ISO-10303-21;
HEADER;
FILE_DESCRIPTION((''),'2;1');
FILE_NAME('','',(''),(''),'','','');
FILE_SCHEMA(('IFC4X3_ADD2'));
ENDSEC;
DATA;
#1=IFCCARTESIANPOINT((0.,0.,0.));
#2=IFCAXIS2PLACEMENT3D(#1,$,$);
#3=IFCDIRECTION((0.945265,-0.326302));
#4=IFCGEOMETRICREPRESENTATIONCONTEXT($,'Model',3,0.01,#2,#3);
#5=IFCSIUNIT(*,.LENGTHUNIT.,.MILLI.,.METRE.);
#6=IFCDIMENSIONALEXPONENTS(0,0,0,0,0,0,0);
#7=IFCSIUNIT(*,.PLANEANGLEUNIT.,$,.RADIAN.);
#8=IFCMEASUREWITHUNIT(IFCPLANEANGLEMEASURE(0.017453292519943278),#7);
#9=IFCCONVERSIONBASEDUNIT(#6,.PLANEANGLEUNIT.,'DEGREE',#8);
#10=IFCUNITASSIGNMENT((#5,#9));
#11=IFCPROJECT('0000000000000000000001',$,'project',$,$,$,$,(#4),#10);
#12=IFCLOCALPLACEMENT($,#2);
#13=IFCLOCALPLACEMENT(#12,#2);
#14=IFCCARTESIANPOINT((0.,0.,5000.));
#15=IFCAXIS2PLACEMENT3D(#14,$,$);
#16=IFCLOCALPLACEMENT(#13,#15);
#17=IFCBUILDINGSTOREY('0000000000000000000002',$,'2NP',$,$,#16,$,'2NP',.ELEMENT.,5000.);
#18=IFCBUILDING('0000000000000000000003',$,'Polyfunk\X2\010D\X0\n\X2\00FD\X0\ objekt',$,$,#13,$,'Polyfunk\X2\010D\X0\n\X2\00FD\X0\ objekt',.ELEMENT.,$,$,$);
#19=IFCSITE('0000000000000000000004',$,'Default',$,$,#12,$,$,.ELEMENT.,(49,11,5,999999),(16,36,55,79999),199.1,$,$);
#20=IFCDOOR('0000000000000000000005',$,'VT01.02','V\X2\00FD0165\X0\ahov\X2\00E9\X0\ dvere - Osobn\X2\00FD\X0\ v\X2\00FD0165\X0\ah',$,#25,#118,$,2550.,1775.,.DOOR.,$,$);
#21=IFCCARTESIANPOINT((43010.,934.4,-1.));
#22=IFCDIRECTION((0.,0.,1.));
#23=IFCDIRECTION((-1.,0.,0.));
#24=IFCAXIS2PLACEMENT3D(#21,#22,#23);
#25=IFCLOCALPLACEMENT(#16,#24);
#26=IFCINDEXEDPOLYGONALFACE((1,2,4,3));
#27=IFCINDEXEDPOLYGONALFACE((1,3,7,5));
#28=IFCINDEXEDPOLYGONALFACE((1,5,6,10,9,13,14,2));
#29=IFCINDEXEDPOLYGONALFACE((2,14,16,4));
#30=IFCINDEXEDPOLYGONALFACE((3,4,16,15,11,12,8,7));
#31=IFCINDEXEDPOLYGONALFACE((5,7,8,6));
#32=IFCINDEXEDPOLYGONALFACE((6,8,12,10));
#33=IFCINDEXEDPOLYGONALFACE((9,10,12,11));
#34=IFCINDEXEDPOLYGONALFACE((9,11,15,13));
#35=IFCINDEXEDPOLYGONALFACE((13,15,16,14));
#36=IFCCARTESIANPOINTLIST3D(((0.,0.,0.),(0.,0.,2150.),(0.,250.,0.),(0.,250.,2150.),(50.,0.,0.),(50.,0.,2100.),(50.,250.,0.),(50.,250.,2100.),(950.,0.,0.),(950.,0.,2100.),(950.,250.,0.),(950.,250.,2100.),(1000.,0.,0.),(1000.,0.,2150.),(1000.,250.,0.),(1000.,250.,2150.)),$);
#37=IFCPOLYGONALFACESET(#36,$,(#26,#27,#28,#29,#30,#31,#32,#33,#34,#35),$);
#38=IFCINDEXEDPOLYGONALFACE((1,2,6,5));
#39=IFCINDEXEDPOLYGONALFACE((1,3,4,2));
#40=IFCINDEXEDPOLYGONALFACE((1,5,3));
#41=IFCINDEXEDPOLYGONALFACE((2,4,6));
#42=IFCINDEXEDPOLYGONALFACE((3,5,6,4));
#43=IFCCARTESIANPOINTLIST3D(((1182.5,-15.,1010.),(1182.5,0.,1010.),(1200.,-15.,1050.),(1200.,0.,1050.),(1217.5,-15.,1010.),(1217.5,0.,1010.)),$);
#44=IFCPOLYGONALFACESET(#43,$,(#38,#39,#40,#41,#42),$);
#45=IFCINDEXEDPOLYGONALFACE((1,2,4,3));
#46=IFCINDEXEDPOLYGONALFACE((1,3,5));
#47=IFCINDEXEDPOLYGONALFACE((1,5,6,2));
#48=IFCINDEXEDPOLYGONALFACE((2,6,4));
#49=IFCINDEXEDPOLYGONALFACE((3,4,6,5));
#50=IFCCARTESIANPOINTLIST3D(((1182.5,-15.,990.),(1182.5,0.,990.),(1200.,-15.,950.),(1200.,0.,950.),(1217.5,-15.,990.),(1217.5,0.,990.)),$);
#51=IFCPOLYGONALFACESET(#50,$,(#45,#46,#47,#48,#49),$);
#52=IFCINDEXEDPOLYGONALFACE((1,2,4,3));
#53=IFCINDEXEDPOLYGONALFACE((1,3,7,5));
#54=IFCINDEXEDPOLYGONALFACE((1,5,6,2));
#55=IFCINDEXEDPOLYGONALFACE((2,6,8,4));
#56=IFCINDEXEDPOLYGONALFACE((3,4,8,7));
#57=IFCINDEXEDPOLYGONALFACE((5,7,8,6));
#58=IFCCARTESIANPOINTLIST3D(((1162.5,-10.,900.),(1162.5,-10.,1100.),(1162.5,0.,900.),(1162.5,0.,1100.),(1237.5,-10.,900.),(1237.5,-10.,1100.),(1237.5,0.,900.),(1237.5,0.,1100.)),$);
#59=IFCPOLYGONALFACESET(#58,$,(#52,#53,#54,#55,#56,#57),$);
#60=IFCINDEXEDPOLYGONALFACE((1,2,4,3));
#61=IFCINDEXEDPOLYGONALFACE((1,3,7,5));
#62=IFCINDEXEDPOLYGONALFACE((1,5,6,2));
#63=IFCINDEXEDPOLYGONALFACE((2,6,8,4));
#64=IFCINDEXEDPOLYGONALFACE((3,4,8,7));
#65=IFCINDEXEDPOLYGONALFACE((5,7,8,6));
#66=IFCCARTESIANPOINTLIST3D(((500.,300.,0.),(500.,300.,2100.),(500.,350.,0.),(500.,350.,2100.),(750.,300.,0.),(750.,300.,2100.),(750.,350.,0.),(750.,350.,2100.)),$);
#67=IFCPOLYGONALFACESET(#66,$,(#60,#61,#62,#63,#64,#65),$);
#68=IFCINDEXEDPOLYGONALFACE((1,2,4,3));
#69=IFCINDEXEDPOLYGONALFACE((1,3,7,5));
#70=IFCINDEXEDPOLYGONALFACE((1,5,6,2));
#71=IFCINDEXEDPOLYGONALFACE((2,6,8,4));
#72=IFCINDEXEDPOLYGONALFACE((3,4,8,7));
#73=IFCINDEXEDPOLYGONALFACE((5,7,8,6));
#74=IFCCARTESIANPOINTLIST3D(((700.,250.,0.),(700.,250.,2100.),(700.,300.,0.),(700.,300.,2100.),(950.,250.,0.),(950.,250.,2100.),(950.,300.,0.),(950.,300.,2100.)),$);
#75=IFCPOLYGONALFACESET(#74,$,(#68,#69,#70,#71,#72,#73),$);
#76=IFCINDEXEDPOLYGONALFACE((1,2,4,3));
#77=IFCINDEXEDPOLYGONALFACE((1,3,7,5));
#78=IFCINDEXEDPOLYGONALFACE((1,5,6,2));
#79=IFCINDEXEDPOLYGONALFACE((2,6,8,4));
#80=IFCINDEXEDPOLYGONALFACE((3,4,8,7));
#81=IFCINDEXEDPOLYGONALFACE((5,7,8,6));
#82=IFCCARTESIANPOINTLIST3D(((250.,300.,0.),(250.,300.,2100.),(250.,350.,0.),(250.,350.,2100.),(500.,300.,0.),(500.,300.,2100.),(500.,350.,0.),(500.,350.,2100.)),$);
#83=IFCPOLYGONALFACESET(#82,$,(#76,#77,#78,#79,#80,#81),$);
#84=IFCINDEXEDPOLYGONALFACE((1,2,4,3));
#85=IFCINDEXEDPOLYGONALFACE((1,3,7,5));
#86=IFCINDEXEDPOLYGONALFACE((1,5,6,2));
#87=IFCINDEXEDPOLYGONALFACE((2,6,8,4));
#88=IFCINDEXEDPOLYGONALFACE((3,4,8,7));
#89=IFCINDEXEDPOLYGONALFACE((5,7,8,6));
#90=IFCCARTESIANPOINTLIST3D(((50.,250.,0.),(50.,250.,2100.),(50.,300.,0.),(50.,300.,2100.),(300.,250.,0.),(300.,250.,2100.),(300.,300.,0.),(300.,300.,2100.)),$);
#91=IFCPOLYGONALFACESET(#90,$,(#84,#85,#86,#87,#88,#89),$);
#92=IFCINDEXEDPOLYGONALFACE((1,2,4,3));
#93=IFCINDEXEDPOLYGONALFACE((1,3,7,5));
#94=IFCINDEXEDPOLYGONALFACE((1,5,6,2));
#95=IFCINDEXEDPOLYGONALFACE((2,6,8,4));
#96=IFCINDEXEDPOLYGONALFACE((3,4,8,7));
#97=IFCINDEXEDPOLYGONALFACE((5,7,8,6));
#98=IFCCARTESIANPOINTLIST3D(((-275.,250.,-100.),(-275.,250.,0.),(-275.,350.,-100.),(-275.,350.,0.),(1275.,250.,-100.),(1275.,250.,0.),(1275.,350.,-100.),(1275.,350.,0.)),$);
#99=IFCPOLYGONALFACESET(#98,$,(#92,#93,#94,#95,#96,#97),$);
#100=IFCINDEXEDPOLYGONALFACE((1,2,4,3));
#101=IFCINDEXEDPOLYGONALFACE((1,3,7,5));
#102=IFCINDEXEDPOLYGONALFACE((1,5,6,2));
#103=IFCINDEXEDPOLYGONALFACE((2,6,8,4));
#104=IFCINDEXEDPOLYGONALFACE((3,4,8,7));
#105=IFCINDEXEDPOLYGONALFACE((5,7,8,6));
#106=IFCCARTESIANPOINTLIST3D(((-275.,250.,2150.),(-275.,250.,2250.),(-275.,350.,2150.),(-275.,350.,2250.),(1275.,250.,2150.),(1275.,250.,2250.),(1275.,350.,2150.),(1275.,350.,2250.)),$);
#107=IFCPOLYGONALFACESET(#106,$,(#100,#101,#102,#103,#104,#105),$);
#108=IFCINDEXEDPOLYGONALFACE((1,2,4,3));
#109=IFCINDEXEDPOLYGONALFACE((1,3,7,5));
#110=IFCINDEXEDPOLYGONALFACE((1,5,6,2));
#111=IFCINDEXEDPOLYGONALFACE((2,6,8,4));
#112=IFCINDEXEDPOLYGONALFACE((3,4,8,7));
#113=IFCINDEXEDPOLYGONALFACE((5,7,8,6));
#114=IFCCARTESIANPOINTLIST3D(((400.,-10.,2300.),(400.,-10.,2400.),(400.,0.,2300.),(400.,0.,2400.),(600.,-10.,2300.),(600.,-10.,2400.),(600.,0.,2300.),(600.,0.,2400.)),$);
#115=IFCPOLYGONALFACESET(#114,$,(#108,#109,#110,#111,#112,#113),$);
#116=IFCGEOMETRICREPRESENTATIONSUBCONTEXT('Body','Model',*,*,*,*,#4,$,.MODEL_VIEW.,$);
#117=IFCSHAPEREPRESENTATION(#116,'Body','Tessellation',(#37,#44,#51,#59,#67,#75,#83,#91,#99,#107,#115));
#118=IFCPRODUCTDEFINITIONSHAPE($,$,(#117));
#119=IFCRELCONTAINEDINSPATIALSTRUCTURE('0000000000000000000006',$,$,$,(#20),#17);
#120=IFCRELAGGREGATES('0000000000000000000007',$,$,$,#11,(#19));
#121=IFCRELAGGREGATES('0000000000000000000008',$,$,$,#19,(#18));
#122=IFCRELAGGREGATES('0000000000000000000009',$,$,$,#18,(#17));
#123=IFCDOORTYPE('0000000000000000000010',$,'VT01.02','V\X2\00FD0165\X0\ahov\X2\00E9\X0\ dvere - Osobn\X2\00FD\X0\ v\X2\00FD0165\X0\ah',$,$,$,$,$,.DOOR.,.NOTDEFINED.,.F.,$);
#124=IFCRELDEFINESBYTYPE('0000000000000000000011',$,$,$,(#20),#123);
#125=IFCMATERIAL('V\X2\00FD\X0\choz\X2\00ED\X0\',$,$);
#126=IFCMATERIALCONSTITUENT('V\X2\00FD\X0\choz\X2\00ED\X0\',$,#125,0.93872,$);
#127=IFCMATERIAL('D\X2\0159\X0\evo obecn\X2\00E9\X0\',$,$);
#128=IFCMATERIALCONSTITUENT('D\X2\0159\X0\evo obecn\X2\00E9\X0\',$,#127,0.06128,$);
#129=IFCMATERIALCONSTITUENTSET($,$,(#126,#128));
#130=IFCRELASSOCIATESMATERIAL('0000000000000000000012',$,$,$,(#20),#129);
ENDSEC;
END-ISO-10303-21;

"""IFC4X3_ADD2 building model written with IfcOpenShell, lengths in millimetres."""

from ifc_helpers import new_model, entity, si_unit, converted_unit, direction, frame, frame_2d, origin, origin_2d_with_axis, place, context, subcontext, project, spatial, polyline, rectangle, outline, extrude, source, transform, mapped, material, constituent, constituent_set, type_object, type_shapes, element, save


model = new_model("IFC4X3_ADD2")

# Units and contexts
model_context = context("Model", 3, precision=0.01, world=origin(), true_north=direction((0.945265, -0.326302)))
body_context = subcontext(model_context, "Body", "Model", "MODEL_VIEW")
ifc_project = project(units=[si_unit("LENGTHUNIT", "METRE", prefix="MILLI"), converted_unit("PLANEANGLEUNIT", "DEGREE", entity("IfcPlaneAngleMeasure", 0.017453292519943278), si_unit("PLANEANGLEUNIT", "RADIAN"), dimensions=[0, 0, 0, 0, 0, 0, 0])], contexts=[model_context])

# Site, building, storey
site_placement = place(None, origin())
site = spatial("IfcSite", under=ifc_project, at=site_placement, Name="Default", CompositionType="ELEMENT", RefLatitude=(49, 11, 5, 999999), RefLongitude=(16, 36, 55, 79999), RefElevation=199.1)
building_placement = place(site_placement, origin())
building = spatial("IfcBuilding", under=site, at=building_placement, Name="Polyfunkčný objekt", LongName="Polyfunkčný objekt", CompositionType="ELEMENT")
storey_placement = place(building_placement, frame((0.0, 0.0, 5000.0)))
storey = spatial("IfcBuildingStorey", under=building, at=storey_placement, Name="2NP", LongName="2NP", CompositionType="ELEMENT", Elevation=5000.0)

# Shared definitions
ifc_material_1 = material(Name="Dřevo obecné")

# Door
ifc_material_2 = material(Name="Výchozí")
ifc_constituent_1 = constituent(ifc_material_2, Name="Výchozí", fraction=0.93872)
ifc_constituent_2 = constituent(ifc_material_1, Name="Dřevo obecné", fraction=0.06128)
ifc_constituent_set_1 = constituent_set(constituents=[ifc_constituent_1, ifc_constituent_2])
door_type = type_object("IfcDoorType", Name="VT01.02", Description="Výťahové dvere - Osobný výťah", OperationType="NOTDEFINED", ParameterTakesPrecedence=False, PredefinedType="DOOR")
shared_shape_1 = source(origin(), body_context, "Body", "SweptSolid", [
    extrude(outline(polyline([(-1087.5, -500.0), (1062.5, -500.0), (1062.5, -450.0), (-1037.5, -450.0), (-1037.5, 450.0), (1062.5, 450.0), (1062.5, 500.0), (-1087.5, 500.0), (-1087.5, -500.0)])), frame((500.0, 0.0, 1062.5), z_axis=(0.0, 1.0, 0.0), x_axis=(0.0, 0.0, -1.0)), (0.0, 0.0, 1.0), 250.0),
    extrude(outline(polyline([(-24.4, -10.7), (19.2, -10.7), (5.2, 21.4), (-24.4, -10.7)])), frame((1200.0, -15.0, 1023.3), z_axis=(0.0, 1.0, 0.0), x_axis=(0.400819, 0.0, -0.916157)), (0.0, 0.0, 1.0), 15.0),
    extrude(outline(polyline([(-24.4, -10.7), (19.2, -10.7), (5.2, 21.4), (-24.4, -10.7)])), frame((1200.0, -15.0, 976.7), z_axis=(0.0, 1.0, 0.0), x_axis=(-0.400819, 0.0, 0.916157)), (0.0, 0.0, 1.0), 15.0),
    extrude(rectangle(XDim=10.0, YDim=75.0, at=frame_2d((0.0, 0.0), x_axis=(1.0, 0.0))), frame((1200.0, -5.0, 900.0), z_axis=(0.0, 0.0, 1.0), x_axis=(0.0, 1.0, 0.0)), (0.0, 0.0, 1.0), 200.0),
    extrude(rectangle(XDim=50.0, YDim=250.0, at=origin_2d_with_axis()), frame((625.0, 325.0, 0.0), z_axis=(0.0, 0.0, 1.0), x_axis=(0.0, -1.0, 0.0)), (0.0, 0.0, 1.0), 2100.0),
    extrude(rectangle(XDim=50.0, YDim=250.0, at=frame_2d((0.0, 0.0), x_axis=(1.0, 0.0))), frame((825.0, 275.0, 0.0), z_axis=(0.0, 0.0, 1.0), x_axis=(0.0, -1.0, 0.0)), (0.0, 0.0, 1.0), 2100.0),
    extrude(rectangle(XDim=250.0, YDim=50.0, at=frame_2d((0.0, 0.0), x_axis=(1.0, 0.0))), frame((375.0, 325.0, 0.0), z_axis=(0.0, 0.0, 1.0), x_axis=(-1.0, 0.0, 0.0)), (0.0, 0.0, 1.0), 2100.0),
    extrude(rectangle(XDim=250.0, YDim=50.0, at=frame_2d((0.0, 0.0), x_axis=(1.0, 0.0))), frame((175.0, 275.0, 0.0), z_axis=(0.0, 0.0, 1.0), x_axis=(-1.0, 0.0, 0.0)), (0.0, 0.0, 1.0), 2100.0),
    extrude(rectangle(XDim=1550.0, YDim=100.0, at=frame_2d((0.0, 0.0), x_axis=(1.0, 0.0))), frame((500.0, 300.0, -100.0), z_axis=(0.0, 0.0, 1.0), x_axis=(-1.0, 0.0, 0.0)), (0.0, 0.0, 1.0), 100.0),
    extrude(rectangle(XDim=1550.0, YDim=100.0, at=frame_2d((0.0, 0.0), x_axis=(1.0, 0.0))), frame((500.0, 300.0, 2150.0), z_axis=(0.0, 0.0, 1.0), x_axis=(-1.0, 0.0, 0.0)), (0.0, 0.0, 1.0), 100.0),
    extrude(rectangle(XDim=10.0, YDim=200.0, at=frame_2d((0.0, 0.0), x_axis=(1.0, 0.0))), frame((500.0, -5.0, 2300.0), z_axis=(0.0, 0.0, 1.0), x_axis=(0.0, 1.0, 0.0)), (0.0, 0.0, 1.0), 100.0),
])
type_shapes(door_type, [shared_shape_1])
door_placement = place(storey_placement, frame((43010.0, 934.4, -1.0), z_axis=(0.0, 0.0, 1.0), x_axis=(-1.0, 0.0, 0.0)))
element("IfcDoor", 1, at=door_placement, inside=storey, type_object=door_type, material=ifc_constituent_set_1, Name="VT01.02", Description="Výťahové dvere - Osobný výťah", OverallHeight=2550.0, OverallWidth=1775.0, PredefinedType="DOOR", context=body_context, shape_type="MappedRepresentation", body=[
    mapped(shared_shape_1, transform((0.0, 0.0, 0.0), scale=1.0)),
])

save(model, "model.ifc")
